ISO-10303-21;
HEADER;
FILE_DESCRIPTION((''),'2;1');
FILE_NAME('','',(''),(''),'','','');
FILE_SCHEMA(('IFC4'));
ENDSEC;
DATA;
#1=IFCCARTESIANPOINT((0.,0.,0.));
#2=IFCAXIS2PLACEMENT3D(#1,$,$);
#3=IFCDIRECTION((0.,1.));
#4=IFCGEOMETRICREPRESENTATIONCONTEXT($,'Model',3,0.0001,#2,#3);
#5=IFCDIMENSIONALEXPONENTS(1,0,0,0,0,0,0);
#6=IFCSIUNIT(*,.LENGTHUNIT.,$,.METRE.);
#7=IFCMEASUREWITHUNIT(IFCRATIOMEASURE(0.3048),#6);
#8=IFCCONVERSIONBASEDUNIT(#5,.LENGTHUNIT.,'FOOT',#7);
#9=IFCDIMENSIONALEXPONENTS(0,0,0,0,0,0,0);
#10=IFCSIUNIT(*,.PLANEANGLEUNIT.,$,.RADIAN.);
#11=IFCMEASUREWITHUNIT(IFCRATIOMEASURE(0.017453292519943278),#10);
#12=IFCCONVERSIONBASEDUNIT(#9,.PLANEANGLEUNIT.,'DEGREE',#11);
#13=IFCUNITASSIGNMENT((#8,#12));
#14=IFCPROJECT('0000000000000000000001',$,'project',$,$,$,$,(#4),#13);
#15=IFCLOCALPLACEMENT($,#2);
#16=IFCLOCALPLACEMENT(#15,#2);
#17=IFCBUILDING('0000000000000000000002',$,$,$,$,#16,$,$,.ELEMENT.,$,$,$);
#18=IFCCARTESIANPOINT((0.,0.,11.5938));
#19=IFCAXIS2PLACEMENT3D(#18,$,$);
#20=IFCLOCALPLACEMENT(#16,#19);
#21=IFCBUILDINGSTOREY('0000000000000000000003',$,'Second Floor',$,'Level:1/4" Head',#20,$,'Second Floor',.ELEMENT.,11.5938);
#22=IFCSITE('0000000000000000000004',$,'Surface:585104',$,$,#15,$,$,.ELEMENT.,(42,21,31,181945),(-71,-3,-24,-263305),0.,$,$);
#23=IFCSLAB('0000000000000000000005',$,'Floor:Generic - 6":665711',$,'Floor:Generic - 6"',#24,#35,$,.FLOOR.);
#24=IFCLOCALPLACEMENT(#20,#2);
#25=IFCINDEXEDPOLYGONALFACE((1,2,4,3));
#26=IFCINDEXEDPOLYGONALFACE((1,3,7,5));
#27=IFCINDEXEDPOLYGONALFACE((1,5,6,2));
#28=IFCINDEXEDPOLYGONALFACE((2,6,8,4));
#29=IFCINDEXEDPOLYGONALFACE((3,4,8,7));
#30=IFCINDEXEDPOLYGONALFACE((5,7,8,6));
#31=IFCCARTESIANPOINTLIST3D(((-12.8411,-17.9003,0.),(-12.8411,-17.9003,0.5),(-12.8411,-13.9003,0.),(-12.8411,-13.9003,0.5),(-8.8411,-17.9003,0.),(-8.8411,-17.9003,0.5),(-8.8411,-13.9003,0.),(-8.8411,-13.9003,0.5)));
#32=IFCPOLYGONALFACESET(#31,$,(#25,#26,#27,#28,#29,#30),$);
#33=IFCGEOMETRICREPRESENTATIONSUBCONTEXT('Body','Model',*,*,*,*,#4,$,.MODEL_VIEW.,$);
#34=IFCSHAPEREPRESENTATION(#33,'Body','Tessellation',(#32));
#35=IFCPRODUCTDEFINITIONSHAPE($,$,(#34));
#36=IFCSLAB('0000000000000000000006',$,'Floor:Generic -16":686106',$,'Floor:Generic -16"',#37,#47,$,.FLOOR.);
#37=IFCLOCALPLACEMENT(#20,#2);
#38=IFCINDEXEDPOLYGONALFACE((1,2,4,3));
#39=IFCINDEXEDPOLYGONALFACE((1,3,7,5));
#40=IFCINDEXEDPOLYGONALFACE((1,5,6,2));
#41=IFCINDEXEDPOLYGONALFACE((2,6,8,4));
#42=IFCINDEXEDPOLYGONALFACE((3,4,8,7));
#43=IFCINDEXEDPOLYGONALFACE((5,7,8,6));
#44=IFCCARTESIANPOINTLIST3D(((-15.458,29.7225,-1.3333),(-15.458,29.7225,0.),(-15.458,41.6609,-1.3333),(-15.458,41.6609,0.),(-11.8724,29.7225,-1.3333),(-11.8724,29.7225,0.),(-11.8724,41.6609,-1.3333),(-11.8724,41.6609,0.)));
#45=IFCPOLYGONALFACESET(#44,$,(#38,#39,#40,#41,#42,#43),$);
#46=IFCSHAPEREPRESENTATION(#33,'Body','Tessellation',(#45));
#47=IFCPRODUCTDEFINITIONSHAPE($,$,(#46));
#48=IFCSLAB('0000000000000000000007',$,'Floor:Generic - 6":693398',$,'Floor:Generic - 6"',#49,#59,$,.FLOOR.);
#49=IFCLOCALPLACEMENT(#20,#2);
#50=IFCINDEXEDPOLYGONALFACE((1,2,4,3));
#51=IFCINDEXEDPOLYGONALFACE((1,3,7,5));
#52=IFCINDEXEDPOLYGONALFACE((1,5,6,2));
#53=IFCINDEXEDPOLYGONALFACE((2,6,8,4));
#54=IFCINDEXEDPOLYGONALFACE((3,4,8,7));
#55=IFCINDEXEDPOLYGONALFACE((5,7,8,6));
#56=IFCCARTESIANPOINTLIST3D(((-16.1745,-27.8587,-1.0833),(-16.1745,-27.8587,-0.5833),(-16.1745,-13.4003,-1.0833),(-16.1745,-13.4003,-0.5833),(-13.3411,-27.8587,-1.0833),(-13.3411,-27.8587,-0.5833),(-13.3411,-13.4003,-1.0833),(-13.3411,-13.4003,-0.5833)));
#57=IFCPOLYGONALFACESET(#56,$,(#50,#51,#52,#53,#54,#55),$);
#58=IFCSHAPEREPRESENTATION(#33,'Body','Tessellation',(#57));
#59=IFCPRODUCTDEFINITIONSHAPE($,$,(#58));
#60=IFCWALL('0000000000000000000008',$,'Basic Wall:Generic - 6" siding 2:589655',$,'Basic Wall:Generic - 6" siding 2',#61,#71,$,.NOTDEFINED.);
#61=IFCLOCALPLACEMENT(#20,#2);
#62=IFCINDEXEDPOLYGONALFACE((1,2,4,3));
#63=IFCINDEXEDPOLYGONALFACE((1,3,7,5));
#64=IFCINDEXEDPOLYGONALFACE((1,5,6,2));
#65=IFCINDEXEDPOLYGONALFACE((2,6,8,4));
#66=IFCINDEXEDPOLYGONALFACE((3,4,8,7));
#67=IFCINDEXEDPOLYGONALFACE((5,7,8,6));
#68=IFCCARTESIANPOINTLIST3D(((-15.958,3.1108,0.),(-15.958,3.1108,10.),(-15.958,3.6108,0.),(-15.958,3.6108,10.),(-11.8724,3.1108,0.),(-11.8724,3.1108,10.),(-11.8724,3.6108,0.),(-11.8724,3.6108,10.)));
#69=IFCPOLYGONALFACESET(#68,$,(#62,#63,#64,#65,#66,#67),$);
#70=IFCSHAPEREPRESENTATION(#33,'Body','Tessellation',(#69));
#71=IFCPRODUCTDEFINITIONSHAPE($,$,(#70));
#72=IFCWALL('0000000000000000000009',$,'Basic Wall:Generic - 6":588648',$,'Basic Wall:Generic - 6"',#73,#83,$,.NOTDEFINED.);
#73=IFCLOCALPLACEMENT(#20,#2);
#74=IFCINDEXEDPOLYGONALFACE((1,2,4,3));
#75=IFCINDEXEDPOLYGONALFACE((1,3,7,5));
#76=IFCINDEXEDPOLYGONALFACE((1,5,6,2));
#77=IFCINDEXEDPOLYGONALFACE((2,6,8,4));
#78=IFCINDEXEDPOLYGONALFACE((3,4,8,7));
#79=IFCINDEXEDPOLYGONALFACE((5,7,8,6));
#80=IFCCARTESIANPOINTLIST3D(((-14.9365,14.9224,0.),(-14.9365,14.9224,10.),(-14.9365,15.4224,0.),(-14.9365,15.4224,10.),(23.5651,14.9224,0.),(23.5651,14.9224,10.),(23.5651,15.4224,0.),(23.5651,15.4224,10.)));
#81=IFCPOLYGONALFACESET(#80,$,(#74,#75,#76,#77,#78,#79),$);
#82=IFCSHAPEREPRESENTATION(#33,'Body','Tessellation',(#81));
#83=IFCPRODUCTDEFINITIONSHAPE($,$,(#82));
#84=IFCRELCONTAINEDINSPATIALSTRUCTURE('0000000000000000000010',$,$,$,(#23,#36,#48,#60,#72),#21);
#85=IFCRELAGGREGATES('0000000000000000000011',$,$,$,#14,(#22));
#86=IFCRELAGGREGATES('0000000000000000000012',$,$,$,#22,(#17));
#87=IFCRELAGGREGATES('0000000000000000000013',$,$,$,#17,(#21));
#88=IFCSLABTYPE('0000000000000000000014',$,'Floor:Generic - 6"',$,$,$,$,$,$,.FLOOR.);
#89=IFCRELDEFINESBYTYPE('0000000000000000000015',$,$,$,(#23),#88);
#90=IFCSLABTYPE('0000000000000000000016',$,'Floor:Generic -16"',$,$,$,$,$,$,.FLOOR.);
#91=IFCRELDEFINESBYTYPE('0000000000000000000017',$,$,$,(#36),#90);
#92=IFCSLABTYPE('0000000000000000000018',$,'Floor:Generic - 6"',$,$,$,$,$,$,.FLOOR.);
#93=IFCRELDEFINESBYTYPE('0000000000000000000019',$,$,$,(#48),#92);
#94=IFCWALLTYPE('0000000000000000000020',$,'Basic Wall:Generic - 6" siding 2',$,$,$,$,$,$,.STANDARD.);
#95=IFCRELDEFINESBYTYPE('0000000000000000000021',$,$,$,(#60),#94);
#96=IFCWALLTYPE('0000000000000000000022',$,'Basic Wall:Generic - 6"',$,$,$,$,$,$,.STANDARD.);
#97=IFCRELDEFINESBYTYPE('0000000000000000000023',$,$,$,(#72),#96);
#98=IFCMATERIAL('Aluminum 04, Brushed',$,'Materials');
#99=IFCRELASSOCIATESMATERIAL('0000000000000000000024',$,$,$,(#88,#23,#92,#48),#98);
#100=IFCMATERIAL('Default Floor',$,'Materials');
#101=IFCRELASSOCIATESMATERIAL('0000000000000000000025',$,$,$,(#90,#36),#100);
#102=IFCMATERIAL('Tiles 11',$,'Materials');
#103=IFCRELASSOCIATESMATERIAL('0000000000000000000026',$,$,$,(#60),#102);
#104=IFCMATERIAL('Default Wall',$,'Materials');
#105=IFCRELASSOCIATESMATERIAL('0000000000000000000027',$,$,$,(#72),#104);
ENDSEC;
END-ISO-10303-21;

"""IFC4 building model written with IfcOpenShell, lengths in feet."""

from ifc_helpers import new_model, entity, si_unit, converted_unit, direction, frame, origin, place, context, subcontext, project, spatial, indexed_curve, outline, extrude, material, type_object, element, save


model = new_model("IFC4")

# Units and contexts
model_context = context("Model", 3, precision=0.0001, world=origin(), true_north=direction((0.0, 1.0)))
body_context = subcontext(model_context, "Body", "Model", "MODEL_VIEW")
ifc_project = project(units=[converted_unit("LENGTHUNIT", "FOOT", entity("IfcRatioMeasure", 0.3048), si_unit("LENGTHUNIT", "METRE"), dimensions=[1, 0, 0, 0, 0, 0, 0]), converted_unit("PLANEANGLEUNIT", "DEGREE", entity("IfcRatioMeasure", 0.017453292519943278), si_unit("PLANEANGLEUNIT", "RADIAN"), dimensions=[0, 0, 0, 0, 0, 0, 0])], contexts=[model_context])

# Site, building, storey
site_placement = place(None, origin())
site = spatial("IfcSite", under=ifc_project, at=site_placement, Name="Surface:585104", CompositionType="ELEMENT", RefLatitude=(42, 21, 31, 181945), RefLongitude=(-71, -3, -24, -263305), RefElevation=0.0)
building_placement = place(site_placement, origin())
building = spatial("IfcBuilding", under=site, at=building_placement, CompositionType="ELEMENT")
storey_placement = place(building_placement, frame((0.0, 0.0, 11.5938)))
storey = spatial("IfcBuildingStorey", under=building, at=storey_placement, Name="Second Floor", ObjectType="Level:1/4\" Head", LongName="Second Floor", CompositionType="ELEMENT", Elevation=11.5938)

# Slabs
ifc_material_1 = material(Name="Aluminum 04, Brushed", Category="Materials")
slab_type_1 = type_object("IfcSlabType", Name="Floor:Generic - 6\"", PredefinedType="FLOOR", material=ifc_material_1)
slab_1_placement = place(storey_placement, origin())
element("IfcSlab", 1, at=slab_1_placement, inside=storey, type_object=slab_type_1, material=ifc_material_1, Name="Floor:Generic - 6\":665711", ObjectType="Floor:Generic - 6\"", PredefinedType="FLOOR", context=body_context, shape_type="SweptSolid", body=[
    extrude(outline(indexed_curve([(-2.0, -2.0), (2.0, -2.0), (2.0, 2.0), (-2.0, 2.0), (-2.0, -2.0)], self_intersect=False)), frame((-10.8411, -15.9003, 0.5), z_axis=(0.0, 0.0, -1.0), x_axis=(0.0, 1.0, 0.0)), (0.0, 0.0, 1.0), 0.5),
])
ifc_material_2 = material(Name="Default Floor", Category="Materials")
slab_type_2 = type_object("IfcSlabType", Name="Floor:Generic -16\"", PredefinedType="FLOOR", material=ifc_material_2)
slab_2_placement = place(storey_placement, origin())
element("IfcSlab", 2, at=slab_2_placement, inside=storey, type_object=slab_type_2, material=ifc_material_2, Name="Floor:Generic -16\":686106", ObjectType="Floor:Generic -16\"", PredefinedType="FLOOR", context=body_context, shape_type="SweptSolid", body=[
    extrude(outline(indexed_curve([(-5.9692, -1.7928), (5.9692, -1.7928), (5.9692, 1.7928), (-5.9692, 1.7928), (-5.9692, -1.7928)], self_intersect=False)), frame((-13.6652, 35.6917, 0.0), z_axis=(0.0, 0.0, -1.0), x_axis=(0.0, 1.0, 0.0)), (0.0, 0.0, 1.0), 1.3333),
])
slab_type_3 = type_object("IfcSlabType", Name="Floor:Generic - 6\"", PredefinedType="FLOOR", material=ifc_material_1)
slab_3_placement = place(storey_placement, origin())
element("IfcSlab", 3, at=slab_3_placement, inside=storey, type_object=slab_type_3, material=ifc_material_1, Name="Floor:Generic - 6\":693398", ObjectType="Floor:Generic - 6\"", PredefinedType="FLOOR", context=body_context, shape_type="SweptSolid", body=[
    extrude(outline(indexed_curve([(-7.2292, -1.4167), (7.2292, -1.4167), (7.2292, 1.4167), (-7.2292, 1.4167), (-7.2292, -1.4167)], self_intersect=False)), frame((-14.7578, -20.6295, -0.5833), z_axis=(0.0, 0.0, -1.0), x_axis=(0.0, 1.0, 0.0)), (0.0, 0.0, 1.0), 0.5),
])

# Walls
ifc_material_3 = material(Name="Tiles 11", Category="Materials")
wall_type_1 = type_object("IfcWallType", Name="Basic Wall:Generic - 6\" siding 2", PredefinedType="STANDARD")
wall_1_placement = place(storey_placement, frame((-11.3727, 3.3608, 0.0), z_axis=(0.0, 0.0, 1.0), x_axis=(-1.0, 0.0, 0.0)))
element("IfcWall", 4, at=wall_1_placement, inside=storey, type_object=wall_type_1, material=ifc_material_3, Name="Basic Wall:Generic - 6\" siding 2:589655", ObjectType="Basic Wall:Generic - 6\" siding 2", PredefinedType="NOTDEFINED", context=body_context, shape_type="SweptSolid", body=[
    extrude(outline(indexed_curve([(-0.25, -2.0428), (0.25, -2.0428), (0.25, 2.0428), (-0.25, 2.0428), (-0.25, -2.0428)], self_intersect=False)), frame((2.5424, 0.0, 0.0), z_axis=(0.0, 0.0, 1.0), x_axis=(0.0, 1.0, 0.0)), (0.0, 0.0, 1.0), 10.0),
])
ifc_material_4 = material(Name="Default Wall", Category="Materials")
wall_type_2 = type_object("IfcWallType", Name="Basic Wall:Generic - 6\"", PredefinedType="STANDARD")
wall_2_placement = place(storey_placement, frame((-14.9365, 15.1724, 0.0)))
element("IfcWall", 5, at=wall_2_placement, inside=storey, type_object=wall_type_2, material=ifc_material_4, Name="Basic Wall:Generic - 6\":588648", ObjectType="Basic Wall:Generic - 6\"", PredefinedType="NOTDEFINED", context=body_context, shape_type="SweptSolid", body=[
    extrude(outline(indexed_curve([(-0.25, -19.2508), (0.25, -19.2508), (0.25, 19.2508), (-0.25, 19.2508), (-0.25, -19.2508)], self_intersect=False)), frame((19.2508, 0.0, 0.0), z_axis=(0.0, 0.0, 1.0), x_axis=(0.0, 1.0, 0.0)), (0.0, 0.0, 1.0), 10.0),
])

save(model, "model.ifc")
